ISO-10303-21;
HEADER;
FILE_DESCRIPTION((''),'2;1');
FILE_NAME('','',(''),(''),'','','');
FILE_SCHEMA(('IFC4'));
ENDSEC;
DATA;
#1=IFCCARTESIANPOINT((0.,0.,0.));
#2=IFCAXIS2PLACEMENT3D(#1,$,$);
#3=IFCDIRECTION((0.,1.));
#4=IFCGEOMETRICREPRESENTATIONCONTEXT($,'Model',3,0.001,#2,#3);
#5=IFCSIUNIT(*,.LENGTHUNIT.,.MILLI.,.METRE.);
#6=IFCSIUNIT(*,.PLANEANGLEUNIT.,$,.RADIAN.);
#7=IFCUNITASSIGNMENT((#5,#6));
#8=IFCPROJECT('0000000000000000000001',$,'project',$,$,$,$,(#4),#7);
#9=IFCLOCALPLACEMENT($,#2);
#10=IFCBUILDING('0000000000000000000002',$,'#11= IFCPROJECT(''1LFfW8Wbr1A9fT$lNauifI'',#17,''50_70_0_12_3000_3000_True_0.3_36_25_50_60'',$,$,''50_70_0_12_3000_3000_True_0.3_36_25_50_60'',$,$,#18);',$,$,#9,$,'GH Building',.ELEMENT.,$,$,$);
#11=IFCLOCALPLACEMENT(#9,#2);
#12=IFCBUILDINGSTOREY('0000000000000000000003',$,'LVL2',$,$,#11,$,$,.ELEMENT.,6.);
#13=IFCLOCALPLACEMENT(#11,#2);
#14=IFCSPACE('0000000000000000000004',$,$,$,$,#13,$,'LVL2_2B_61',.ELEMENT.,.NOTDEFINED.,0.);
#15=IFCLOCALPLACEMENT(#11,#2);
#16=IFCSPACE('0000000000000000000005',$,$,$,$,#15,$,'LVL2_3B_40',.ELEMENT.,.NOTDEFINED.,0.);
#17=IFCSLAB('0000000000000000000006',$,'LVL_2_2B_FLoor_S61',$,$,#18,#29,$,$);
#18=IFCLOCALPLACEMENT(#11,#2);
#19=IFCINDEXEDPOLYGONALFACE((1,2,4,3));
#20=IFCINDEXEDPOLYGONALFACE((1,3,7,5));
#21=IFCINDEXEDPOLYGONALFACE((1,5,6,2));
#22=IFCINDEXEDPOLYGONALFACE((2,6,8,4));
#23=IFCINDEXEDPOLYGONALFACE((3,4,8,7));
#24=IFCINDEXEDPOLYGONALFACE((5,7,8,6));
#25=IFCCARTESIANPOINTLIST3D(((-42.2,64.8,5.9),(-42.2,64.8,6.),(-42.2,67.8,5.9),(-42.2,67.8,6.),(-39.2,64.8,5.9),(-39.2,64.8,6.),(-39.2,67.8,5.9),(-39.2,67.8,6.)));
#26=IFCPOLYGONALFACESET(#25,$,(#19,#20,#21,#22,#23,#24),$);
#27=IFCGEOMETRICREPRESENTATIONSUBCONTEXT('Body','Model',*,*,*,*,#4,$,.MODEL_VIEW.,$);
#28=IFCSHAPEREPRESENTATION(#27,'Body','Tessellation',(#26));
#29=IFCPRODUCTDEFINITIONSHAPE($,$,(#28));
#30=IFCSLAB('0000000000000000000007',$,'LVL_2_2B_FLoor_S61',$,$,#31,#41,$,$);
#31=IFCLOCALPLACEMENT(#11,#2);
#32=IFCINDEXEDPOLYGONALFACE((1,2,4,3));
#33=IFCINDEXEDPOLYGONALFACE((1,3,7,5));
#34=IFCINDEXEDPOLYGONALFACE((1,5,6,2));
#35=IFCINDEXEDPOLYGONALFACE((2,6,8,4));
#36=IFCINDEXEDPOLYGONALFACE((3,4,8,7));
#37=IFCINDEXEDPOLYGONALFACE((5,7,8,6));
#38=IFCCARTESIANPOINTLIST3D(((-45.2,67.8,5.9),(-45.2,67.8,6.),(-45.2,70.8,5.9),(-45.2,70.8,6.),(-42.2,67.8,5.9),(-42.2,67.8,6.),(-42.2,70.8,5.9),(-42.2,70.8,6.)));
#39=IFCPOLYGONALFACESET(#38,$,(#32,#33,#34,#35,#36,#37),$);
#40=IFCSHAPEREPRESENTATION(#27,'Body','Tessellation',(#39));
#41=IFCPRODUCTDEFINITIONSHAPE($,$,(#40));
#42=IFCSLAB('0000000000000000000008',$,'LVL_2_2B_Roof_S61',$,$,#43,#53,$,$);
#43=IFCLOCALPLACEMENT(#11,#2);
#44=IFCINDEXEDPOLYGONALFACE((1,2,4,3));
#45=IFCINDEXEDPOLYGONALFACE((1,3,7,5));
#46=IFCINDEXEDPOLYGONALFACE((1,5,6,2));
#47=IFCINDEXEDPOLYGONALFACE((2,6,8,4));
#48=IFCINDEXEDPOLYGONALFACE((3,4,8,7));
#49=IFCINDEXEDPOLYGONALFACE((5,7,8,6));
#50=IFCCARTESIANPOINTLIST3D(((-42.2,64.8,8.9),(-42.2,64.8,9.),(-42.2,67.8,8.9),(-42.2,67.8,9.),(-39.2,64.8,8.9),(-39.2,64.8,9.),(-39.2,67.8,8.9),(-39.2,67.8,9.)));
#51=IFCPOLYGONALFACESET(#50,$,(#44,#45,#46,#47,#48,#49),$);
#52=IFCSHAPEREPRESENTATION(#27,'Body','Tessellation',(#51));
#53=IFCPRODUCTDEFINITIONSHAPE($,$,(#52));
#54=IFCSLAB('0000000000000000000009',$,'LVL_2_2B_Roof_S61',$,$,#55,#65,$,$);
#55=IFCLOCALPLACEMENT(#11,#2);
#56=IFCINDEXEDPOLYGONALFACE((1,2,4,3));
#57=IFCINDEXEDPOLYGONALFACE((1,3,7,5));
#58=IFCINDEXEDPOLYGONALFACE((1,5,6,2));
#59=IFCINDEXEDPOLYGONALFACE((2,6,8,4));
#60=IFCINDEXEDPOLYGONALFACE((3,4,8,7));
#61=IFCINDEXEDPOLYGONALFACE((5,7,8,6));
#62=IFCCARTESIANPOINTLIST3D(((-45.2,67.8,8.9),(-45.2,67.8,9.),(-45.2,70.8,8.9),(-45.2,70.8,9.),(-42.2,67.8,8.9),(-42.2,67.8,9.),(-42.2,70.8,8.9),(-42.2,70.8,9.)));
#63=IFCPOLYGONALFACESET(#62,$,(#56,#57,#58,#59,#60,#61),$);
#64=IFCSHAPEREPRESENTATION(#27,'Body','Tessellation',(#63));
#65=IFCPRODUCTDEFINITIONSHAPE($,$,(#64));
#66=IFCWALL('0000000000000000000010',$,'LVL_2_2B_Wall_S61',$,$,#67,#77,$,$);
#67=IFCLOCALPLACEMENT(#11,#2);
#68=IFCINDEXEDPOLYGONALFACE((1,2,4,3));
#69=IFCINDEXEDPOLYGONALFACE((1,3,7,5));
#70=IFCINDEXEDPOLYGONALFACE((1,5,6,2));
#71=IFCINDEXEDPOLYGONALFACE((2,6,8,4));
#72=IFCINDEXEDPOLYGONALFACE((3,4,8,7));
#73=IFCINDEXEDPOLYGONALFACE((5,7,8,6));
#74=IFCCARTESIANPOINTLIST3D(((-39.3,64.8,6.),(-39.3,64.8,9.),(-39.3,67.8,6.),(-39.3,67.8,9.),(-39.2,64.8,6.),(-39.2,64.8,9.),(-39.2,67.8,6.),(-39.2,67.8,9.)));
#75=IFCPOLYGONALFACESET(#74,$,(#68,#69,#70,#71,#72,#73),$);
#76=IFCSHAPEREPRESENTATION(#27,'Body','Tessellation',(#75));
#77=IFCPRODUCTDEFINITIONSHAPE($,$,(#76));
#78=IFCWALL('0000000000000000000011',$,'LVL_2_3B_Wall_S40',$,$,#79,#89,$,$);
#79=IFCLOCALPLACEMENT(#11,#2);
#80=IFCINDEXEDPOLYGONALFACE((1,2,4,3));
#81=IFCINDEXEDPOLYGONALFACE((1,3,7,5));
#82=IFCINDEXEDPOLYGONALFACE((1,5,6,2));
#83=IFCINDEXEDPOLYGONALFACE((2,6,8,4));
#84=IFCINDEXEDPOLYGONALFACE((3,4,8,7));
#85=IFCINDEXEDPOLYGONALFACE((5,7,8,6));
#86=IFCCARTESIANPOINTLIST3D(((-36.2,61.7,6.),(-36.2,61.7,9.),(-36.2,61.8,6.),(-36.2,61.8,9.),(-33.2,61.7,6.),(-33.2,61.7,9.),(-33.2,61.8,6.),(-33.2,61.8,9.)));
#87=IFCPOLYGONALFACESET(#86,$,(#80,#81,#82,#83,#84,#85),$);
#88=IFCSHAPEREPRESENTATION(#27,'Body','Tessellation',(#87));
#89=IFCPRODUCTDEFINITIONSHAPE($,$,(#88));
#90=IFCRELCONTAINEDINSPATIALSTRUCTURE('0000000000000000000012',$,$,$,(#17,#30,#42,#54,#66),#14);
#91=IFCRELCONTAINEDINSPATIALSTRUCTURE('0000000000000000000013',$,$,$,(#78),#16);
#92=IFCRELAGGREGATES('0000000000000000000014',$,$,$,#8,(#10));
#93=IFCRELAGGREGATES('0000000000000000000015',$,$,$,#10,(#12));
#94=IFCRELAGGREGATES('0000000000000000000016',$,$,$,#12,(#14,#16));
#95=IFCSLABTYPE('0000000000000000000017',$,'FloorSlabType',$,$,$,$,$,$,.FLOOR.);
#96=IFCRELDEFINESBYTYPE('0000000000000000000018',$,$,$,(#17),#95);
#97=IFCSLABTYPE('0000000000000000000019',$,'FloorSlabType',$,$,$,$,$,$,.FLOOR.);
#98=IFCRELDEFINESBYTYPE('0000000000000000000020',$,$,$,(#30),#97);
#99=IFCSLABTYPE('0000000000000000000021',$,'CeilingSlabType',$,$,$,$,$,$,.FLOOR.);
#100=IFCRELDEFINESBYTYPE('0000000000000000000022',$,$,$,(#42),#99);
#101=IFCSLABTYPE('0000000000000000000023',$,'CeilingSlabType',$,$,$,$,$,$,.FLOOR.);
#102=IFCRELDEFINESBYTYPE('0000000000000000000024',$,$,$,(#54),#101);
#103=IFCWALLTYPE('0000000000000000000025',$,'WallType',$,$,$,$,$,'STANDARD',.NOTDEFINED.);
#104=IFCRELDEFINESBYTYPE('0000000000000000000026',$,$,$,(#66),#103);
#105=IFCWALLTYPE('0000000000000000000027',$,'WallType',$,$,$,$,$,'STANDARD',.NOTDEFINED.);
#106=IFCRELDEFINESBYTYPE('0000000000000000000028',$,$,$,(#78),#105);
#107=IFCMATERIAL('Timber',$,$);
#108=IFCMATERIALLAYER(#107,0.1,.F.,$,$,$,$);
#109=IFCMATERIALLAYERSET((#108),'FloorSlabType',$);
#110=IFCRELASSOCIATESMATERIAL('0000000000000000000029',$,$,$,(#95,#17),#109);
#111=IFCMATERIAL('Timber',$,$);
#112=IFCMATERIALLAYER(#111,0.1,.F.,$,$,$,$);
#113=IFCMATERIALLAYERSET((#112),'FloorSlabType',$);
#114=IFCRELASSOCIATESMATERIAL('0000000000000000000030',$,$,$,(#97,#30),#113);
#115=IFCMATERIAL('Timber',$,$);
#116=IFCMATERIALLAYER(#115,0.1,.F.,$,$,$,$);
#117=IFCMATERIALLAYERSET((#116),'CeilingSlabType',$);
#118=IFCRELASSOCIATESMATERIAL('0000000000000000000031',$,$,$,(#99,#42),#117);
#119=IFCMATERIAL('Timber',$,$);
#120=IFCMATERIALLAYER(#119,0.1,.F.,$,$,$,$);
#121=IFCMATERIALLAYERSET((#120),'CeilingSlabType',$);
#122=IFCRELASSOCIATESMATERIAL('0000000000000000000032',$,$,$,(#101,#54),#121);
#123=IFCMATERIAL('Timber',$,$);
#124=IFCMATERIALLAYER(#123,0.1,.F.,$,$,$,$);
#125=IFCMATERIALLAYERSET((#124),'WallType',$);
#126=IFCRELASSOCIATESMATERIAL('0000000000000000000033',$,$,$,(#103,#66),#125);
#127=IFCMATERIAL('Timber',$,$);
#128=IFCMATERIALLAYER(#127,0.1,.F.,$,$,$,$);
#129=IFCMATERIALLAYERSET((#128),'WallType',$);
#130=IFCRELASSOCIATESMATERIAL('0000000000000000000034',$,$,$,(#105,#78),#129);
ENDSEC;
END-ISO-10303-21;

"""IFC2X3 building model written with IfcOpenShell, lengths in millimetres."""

from ifc_helpers import new_model, si_unit, direction, frame, frame_2d, origin, place, context, subcontext, project, spatial, rectangle, extrude, material, layer, layer_set, layer_usage, type_object, element, save


model = new_model("IFC2X3")

# Units and contexts
model_context = context("Model", 3, precision=0.001, world=origin(), true_north=direction((0.0, 1.0)))
body_context = subcontext(model_context, "Body", "Model", "MODEL_VIEW")
ifc_project = project(units=[si_unit("LENGTHUNIT", "METRE", prefix="MILLI"), si_unit("PLANEANGLEUNIT", "RADIAN")], contexts=[model_context])

# Building, storey
building_placement = place(None, origin())
building = spatial("IfcBuilding", under=ifc_project, at=building_placement, Name="#11= IFCPROJECT('1LFfW8Wbr1A9fT$lNauifI',#17,'50_70_0_12_3000_3000_True_0.3_36_25_50_60',$,$,'50_70_0_12_3000_3000_True_0.3_36_25_50_60',$,$,#18);", LongName="GH Building", CompositionType="ELEMENT")
storey_placement = place(building_placement, origin())
storey = spatial("IfcBuildingStorey", under=building, at=storey_placement, Name="LVL2", CompositionType="ELEMENT", Elevation=6.0)

# Shared definitions
space_1_placement = place(storey_placement, origin())
space_1 = spatial("IfcSpace", under=storey, at=space_1_placement, LongName="LVL2_2B_61", CompositionType="ELEMENT", InteriorOrExteriorSpace="NOTDEFINED", ElevationWithFlooring=0.0)

# Slabs
ifc_material_1 = material(Name="Timber")
ifc_layer_1 = layer(ifc_material_1, 0.1, ventilated=False)
ifc_layer_set_1 = layer_set([ifc_layer_1], Name="FloorSlabType")
ifc_layer_usage_1 = layer_usage(ifc_layer_set_1, "AXIS3", "NEGATIVE", -0.1)
slab_type_1 = type_object("IfcSlabType", Name="FloorSlabType", PredefinedType="FLOOR", material=ifc_layer_set_1)
slab_1_placement = place(space_1_placement, frame((-42.2, 67.8, 5.9), z_axis=(0.0, 0.0, 1.0), x_axis=(0.0, -1.0, 0.0)))
element("IfcSlab", 1, at=slab_1_placement, inside=space_1, type_object=slab_type_1, material=ifc_layer_usage_1, Name="LVL_2_2B_FLoor_S61", context=body_context, shape_type="SweptSolid", body=[
    extrude(rectangle(XDim=3.0, YDim=3.0, at=frame_2d((1.5, 1.5))), origin(), (0.0, 0.0, 1.0), 0.1),
])
ifc_material_2 = material(Name="Timber")
ifc_layer_2 = layer(ifc_material_2, 0.1, ventilated=False)
ifc_layer_set_2 = layer_set([ifc_layer_2], Name="FloorSlabType")
ifc_layer_usage_2 = layer_usage(ifc_layer_set_2, "AXIS3", "NEGATIVE", -0.1)
slab_type_2 = type_object("IfcSlabType", Name="FloorSlabType", PredefinedType="FLOOR", material=ifc_layer_set_2)
slab_2_placement = place(space_1_placement, frame((-45.2, 70.8, 5.9), z_axis=(0.0, 0.0, 1.0), x_axis=(0.0, -1.0, 0.0)))
element("IfcSlab", 2, at=slab_2_placement, inside=space_1, type_object=slab_type_2, material=ifc_layer_usage_2, Name="LVL_2_2B_FLoor_S61", context=body_context, shape_type="SweptSolid", body=[
    extrude(rectangle(XDim=3.0, YDim=3.0, at=frame_2d((1.5, 1.5))), origin(), (0.0, 0.0, 1.0), 0.1),
])
ifc_material_3 = material(Name="Timber")
ifc_layer_3 = layer(ifc_material_3, 0.1, ventilated=False)
ifc_layer_set_3 = layer_set([ifc_layer_3], Name="CeilingSlabType")
ifc_layer_usage_3 = layer_usage(ifc_layer_set_3, "AXIS3", "NEGATIVE", -0.1)
slab_type_3 = type_object("IfcSlabType", Name="CeilingSlabType", PredefinedType="FLOOR", material=ifc_layer_set_3)
slab_3_placement = place(space_1_placement, frame((-42.2, 67.8, 8.9), z_axis=(0.0, 0.0, 1.0), x_axis=(0.0, -1.0, 0.0)))
element("IfcSlab", 3, at=slab_3_placement, inside=space_1, type_object=slab_type_3, material=ifc_layer_usage_3, Name="LVL_2_2B_Roof_S61", context=body_context, shape_type="SweptSolid", body=[
    extrude(rectangle(XDim=3.0, YDim=3.0, at=frame_2d((1.5, 1.5))), origin(), (0.0, 0.0, 1.0), 0.1),
])
ifc_material_4 = material(Name="Timber")
ifc_layer_4 = layer(ifc_material_4, 0.1, ventilated=False)
ifc_layer_set_4 = layer_set([ifc_layer_4], Name="CeilingSlabType")
ifc_layer_usage_4 = layer_usage(ifc_layer_set_4, "AXIS3", "NEGATIVE", -0.1)
slab_type_4 = type_object("IfcSlabType", Name="CeilingSlabType", PredefinedType="FLOOR", material=ifc_layer_set_4)
slab_4_placement = place(space_1_placement, frame((-45.2, 70.8, 8.9), z_axis=(0.0, 0.0, 1.0), x_axis=(0.0, -1.0, 0.0)))
element("IfcSlab", 4, at=slab_4_placement, inside=space_1, type_object=slab_type_4, material=ifc_layer_usage_4, Name="LVL_2_2B_Roof_S61", context=body_context, shape_type="SweptSolid", body=[
    extrude(rectangle(XDim=3.0, YDim=3.0, at=frame_2d((1.5, 1.5))), origin(), (0.0, 0.0, 1.0), 0.1),
])

# Wall
ifc_material_5 = material(Name="Timber")
ifc_layer_5 = layer(ifc_material_5, 0.1, ventilated=False)
ifc_layer_set_5 = layer_set([ifc_layer_5], Name="WallType")
ifc_layer_usage_5 = layer_usage(ifc_layer_set_5, "AXIS2", "NEGATIVE", 0.0)
wall_type_1 = type_object("IfcWallType", Name="WallType", ElementType="STANDARD", PredefinedType="NOTDEFINED", material=ifc_layer_set_5)
wall_1_placement = place(space_1_placement, frame((-39.2, 67.8, 6.0), z_axis=(0.0, 0.0, 1.0), x_axis=(0.0, -1.0, 0.0)))
element("IfcWall", 5, at=wall_1_placement, inside=space_1, type_object=wall_type_1, material=ifc_layer_usage_5, Name="LVL_2_2B_Wall_S61", context=body_context, shape_type="SweptSolid", body=[
    extrude(rectangle(XDim=3.0, YDim=0.1, at=frame_2d((1.5, -0.1))), origin(), (0.0, 0.0, 1.0), 3.0),
])

# Shared definitions
space_2_placement = place(storey_placement, origin())
space_2 = spatial("IfcSpace", under=storey, at=space_2_placement, LongName="LVL2_3B_40", CompositionType="ELEMENT", InteriorOrExteriorSpace="NOTDEFINED", ElevationWithFlooring=0.0)

# Wall
ifc_material_6 = material(Name="Timber")
ifc_layer_6 = layer(ifc_material_6, 0.1, ventilated=False)
ifc_layer_set_6 = layer_set([ifc_layer_6], Name="WallType")
ifc_layer_usage_6 = layer_usage(ifc_layer_set_6, "AXIS2", "NEGATIVE", 0.0)
wall_type_2 = type_object("IfcWallType", Name="WallType", ElementType="STANDARD", PredefinedType="NOTDEFINED", material=ifc_layer_set_6)
wall_2_placement = place(space_2_placement, frame((-36.2, 61.8, 6.0)))
element("IfcWall", 6, at=wall_2_placement, inside=space_2, type_object=wall_type_2, material=ifc_layer_usage_6, Name="LVL_2_3B_Wall_S40", context=body_context, shape_type="SweptSolid", body=[
    extrude(rectangle(XDim=3.0, YDim=0.1, at=frame_2d((1.5, -0.1))), origin(), (0.0, 0.0, 1.0), 3.0),
])

save(model, "model.ifc")
